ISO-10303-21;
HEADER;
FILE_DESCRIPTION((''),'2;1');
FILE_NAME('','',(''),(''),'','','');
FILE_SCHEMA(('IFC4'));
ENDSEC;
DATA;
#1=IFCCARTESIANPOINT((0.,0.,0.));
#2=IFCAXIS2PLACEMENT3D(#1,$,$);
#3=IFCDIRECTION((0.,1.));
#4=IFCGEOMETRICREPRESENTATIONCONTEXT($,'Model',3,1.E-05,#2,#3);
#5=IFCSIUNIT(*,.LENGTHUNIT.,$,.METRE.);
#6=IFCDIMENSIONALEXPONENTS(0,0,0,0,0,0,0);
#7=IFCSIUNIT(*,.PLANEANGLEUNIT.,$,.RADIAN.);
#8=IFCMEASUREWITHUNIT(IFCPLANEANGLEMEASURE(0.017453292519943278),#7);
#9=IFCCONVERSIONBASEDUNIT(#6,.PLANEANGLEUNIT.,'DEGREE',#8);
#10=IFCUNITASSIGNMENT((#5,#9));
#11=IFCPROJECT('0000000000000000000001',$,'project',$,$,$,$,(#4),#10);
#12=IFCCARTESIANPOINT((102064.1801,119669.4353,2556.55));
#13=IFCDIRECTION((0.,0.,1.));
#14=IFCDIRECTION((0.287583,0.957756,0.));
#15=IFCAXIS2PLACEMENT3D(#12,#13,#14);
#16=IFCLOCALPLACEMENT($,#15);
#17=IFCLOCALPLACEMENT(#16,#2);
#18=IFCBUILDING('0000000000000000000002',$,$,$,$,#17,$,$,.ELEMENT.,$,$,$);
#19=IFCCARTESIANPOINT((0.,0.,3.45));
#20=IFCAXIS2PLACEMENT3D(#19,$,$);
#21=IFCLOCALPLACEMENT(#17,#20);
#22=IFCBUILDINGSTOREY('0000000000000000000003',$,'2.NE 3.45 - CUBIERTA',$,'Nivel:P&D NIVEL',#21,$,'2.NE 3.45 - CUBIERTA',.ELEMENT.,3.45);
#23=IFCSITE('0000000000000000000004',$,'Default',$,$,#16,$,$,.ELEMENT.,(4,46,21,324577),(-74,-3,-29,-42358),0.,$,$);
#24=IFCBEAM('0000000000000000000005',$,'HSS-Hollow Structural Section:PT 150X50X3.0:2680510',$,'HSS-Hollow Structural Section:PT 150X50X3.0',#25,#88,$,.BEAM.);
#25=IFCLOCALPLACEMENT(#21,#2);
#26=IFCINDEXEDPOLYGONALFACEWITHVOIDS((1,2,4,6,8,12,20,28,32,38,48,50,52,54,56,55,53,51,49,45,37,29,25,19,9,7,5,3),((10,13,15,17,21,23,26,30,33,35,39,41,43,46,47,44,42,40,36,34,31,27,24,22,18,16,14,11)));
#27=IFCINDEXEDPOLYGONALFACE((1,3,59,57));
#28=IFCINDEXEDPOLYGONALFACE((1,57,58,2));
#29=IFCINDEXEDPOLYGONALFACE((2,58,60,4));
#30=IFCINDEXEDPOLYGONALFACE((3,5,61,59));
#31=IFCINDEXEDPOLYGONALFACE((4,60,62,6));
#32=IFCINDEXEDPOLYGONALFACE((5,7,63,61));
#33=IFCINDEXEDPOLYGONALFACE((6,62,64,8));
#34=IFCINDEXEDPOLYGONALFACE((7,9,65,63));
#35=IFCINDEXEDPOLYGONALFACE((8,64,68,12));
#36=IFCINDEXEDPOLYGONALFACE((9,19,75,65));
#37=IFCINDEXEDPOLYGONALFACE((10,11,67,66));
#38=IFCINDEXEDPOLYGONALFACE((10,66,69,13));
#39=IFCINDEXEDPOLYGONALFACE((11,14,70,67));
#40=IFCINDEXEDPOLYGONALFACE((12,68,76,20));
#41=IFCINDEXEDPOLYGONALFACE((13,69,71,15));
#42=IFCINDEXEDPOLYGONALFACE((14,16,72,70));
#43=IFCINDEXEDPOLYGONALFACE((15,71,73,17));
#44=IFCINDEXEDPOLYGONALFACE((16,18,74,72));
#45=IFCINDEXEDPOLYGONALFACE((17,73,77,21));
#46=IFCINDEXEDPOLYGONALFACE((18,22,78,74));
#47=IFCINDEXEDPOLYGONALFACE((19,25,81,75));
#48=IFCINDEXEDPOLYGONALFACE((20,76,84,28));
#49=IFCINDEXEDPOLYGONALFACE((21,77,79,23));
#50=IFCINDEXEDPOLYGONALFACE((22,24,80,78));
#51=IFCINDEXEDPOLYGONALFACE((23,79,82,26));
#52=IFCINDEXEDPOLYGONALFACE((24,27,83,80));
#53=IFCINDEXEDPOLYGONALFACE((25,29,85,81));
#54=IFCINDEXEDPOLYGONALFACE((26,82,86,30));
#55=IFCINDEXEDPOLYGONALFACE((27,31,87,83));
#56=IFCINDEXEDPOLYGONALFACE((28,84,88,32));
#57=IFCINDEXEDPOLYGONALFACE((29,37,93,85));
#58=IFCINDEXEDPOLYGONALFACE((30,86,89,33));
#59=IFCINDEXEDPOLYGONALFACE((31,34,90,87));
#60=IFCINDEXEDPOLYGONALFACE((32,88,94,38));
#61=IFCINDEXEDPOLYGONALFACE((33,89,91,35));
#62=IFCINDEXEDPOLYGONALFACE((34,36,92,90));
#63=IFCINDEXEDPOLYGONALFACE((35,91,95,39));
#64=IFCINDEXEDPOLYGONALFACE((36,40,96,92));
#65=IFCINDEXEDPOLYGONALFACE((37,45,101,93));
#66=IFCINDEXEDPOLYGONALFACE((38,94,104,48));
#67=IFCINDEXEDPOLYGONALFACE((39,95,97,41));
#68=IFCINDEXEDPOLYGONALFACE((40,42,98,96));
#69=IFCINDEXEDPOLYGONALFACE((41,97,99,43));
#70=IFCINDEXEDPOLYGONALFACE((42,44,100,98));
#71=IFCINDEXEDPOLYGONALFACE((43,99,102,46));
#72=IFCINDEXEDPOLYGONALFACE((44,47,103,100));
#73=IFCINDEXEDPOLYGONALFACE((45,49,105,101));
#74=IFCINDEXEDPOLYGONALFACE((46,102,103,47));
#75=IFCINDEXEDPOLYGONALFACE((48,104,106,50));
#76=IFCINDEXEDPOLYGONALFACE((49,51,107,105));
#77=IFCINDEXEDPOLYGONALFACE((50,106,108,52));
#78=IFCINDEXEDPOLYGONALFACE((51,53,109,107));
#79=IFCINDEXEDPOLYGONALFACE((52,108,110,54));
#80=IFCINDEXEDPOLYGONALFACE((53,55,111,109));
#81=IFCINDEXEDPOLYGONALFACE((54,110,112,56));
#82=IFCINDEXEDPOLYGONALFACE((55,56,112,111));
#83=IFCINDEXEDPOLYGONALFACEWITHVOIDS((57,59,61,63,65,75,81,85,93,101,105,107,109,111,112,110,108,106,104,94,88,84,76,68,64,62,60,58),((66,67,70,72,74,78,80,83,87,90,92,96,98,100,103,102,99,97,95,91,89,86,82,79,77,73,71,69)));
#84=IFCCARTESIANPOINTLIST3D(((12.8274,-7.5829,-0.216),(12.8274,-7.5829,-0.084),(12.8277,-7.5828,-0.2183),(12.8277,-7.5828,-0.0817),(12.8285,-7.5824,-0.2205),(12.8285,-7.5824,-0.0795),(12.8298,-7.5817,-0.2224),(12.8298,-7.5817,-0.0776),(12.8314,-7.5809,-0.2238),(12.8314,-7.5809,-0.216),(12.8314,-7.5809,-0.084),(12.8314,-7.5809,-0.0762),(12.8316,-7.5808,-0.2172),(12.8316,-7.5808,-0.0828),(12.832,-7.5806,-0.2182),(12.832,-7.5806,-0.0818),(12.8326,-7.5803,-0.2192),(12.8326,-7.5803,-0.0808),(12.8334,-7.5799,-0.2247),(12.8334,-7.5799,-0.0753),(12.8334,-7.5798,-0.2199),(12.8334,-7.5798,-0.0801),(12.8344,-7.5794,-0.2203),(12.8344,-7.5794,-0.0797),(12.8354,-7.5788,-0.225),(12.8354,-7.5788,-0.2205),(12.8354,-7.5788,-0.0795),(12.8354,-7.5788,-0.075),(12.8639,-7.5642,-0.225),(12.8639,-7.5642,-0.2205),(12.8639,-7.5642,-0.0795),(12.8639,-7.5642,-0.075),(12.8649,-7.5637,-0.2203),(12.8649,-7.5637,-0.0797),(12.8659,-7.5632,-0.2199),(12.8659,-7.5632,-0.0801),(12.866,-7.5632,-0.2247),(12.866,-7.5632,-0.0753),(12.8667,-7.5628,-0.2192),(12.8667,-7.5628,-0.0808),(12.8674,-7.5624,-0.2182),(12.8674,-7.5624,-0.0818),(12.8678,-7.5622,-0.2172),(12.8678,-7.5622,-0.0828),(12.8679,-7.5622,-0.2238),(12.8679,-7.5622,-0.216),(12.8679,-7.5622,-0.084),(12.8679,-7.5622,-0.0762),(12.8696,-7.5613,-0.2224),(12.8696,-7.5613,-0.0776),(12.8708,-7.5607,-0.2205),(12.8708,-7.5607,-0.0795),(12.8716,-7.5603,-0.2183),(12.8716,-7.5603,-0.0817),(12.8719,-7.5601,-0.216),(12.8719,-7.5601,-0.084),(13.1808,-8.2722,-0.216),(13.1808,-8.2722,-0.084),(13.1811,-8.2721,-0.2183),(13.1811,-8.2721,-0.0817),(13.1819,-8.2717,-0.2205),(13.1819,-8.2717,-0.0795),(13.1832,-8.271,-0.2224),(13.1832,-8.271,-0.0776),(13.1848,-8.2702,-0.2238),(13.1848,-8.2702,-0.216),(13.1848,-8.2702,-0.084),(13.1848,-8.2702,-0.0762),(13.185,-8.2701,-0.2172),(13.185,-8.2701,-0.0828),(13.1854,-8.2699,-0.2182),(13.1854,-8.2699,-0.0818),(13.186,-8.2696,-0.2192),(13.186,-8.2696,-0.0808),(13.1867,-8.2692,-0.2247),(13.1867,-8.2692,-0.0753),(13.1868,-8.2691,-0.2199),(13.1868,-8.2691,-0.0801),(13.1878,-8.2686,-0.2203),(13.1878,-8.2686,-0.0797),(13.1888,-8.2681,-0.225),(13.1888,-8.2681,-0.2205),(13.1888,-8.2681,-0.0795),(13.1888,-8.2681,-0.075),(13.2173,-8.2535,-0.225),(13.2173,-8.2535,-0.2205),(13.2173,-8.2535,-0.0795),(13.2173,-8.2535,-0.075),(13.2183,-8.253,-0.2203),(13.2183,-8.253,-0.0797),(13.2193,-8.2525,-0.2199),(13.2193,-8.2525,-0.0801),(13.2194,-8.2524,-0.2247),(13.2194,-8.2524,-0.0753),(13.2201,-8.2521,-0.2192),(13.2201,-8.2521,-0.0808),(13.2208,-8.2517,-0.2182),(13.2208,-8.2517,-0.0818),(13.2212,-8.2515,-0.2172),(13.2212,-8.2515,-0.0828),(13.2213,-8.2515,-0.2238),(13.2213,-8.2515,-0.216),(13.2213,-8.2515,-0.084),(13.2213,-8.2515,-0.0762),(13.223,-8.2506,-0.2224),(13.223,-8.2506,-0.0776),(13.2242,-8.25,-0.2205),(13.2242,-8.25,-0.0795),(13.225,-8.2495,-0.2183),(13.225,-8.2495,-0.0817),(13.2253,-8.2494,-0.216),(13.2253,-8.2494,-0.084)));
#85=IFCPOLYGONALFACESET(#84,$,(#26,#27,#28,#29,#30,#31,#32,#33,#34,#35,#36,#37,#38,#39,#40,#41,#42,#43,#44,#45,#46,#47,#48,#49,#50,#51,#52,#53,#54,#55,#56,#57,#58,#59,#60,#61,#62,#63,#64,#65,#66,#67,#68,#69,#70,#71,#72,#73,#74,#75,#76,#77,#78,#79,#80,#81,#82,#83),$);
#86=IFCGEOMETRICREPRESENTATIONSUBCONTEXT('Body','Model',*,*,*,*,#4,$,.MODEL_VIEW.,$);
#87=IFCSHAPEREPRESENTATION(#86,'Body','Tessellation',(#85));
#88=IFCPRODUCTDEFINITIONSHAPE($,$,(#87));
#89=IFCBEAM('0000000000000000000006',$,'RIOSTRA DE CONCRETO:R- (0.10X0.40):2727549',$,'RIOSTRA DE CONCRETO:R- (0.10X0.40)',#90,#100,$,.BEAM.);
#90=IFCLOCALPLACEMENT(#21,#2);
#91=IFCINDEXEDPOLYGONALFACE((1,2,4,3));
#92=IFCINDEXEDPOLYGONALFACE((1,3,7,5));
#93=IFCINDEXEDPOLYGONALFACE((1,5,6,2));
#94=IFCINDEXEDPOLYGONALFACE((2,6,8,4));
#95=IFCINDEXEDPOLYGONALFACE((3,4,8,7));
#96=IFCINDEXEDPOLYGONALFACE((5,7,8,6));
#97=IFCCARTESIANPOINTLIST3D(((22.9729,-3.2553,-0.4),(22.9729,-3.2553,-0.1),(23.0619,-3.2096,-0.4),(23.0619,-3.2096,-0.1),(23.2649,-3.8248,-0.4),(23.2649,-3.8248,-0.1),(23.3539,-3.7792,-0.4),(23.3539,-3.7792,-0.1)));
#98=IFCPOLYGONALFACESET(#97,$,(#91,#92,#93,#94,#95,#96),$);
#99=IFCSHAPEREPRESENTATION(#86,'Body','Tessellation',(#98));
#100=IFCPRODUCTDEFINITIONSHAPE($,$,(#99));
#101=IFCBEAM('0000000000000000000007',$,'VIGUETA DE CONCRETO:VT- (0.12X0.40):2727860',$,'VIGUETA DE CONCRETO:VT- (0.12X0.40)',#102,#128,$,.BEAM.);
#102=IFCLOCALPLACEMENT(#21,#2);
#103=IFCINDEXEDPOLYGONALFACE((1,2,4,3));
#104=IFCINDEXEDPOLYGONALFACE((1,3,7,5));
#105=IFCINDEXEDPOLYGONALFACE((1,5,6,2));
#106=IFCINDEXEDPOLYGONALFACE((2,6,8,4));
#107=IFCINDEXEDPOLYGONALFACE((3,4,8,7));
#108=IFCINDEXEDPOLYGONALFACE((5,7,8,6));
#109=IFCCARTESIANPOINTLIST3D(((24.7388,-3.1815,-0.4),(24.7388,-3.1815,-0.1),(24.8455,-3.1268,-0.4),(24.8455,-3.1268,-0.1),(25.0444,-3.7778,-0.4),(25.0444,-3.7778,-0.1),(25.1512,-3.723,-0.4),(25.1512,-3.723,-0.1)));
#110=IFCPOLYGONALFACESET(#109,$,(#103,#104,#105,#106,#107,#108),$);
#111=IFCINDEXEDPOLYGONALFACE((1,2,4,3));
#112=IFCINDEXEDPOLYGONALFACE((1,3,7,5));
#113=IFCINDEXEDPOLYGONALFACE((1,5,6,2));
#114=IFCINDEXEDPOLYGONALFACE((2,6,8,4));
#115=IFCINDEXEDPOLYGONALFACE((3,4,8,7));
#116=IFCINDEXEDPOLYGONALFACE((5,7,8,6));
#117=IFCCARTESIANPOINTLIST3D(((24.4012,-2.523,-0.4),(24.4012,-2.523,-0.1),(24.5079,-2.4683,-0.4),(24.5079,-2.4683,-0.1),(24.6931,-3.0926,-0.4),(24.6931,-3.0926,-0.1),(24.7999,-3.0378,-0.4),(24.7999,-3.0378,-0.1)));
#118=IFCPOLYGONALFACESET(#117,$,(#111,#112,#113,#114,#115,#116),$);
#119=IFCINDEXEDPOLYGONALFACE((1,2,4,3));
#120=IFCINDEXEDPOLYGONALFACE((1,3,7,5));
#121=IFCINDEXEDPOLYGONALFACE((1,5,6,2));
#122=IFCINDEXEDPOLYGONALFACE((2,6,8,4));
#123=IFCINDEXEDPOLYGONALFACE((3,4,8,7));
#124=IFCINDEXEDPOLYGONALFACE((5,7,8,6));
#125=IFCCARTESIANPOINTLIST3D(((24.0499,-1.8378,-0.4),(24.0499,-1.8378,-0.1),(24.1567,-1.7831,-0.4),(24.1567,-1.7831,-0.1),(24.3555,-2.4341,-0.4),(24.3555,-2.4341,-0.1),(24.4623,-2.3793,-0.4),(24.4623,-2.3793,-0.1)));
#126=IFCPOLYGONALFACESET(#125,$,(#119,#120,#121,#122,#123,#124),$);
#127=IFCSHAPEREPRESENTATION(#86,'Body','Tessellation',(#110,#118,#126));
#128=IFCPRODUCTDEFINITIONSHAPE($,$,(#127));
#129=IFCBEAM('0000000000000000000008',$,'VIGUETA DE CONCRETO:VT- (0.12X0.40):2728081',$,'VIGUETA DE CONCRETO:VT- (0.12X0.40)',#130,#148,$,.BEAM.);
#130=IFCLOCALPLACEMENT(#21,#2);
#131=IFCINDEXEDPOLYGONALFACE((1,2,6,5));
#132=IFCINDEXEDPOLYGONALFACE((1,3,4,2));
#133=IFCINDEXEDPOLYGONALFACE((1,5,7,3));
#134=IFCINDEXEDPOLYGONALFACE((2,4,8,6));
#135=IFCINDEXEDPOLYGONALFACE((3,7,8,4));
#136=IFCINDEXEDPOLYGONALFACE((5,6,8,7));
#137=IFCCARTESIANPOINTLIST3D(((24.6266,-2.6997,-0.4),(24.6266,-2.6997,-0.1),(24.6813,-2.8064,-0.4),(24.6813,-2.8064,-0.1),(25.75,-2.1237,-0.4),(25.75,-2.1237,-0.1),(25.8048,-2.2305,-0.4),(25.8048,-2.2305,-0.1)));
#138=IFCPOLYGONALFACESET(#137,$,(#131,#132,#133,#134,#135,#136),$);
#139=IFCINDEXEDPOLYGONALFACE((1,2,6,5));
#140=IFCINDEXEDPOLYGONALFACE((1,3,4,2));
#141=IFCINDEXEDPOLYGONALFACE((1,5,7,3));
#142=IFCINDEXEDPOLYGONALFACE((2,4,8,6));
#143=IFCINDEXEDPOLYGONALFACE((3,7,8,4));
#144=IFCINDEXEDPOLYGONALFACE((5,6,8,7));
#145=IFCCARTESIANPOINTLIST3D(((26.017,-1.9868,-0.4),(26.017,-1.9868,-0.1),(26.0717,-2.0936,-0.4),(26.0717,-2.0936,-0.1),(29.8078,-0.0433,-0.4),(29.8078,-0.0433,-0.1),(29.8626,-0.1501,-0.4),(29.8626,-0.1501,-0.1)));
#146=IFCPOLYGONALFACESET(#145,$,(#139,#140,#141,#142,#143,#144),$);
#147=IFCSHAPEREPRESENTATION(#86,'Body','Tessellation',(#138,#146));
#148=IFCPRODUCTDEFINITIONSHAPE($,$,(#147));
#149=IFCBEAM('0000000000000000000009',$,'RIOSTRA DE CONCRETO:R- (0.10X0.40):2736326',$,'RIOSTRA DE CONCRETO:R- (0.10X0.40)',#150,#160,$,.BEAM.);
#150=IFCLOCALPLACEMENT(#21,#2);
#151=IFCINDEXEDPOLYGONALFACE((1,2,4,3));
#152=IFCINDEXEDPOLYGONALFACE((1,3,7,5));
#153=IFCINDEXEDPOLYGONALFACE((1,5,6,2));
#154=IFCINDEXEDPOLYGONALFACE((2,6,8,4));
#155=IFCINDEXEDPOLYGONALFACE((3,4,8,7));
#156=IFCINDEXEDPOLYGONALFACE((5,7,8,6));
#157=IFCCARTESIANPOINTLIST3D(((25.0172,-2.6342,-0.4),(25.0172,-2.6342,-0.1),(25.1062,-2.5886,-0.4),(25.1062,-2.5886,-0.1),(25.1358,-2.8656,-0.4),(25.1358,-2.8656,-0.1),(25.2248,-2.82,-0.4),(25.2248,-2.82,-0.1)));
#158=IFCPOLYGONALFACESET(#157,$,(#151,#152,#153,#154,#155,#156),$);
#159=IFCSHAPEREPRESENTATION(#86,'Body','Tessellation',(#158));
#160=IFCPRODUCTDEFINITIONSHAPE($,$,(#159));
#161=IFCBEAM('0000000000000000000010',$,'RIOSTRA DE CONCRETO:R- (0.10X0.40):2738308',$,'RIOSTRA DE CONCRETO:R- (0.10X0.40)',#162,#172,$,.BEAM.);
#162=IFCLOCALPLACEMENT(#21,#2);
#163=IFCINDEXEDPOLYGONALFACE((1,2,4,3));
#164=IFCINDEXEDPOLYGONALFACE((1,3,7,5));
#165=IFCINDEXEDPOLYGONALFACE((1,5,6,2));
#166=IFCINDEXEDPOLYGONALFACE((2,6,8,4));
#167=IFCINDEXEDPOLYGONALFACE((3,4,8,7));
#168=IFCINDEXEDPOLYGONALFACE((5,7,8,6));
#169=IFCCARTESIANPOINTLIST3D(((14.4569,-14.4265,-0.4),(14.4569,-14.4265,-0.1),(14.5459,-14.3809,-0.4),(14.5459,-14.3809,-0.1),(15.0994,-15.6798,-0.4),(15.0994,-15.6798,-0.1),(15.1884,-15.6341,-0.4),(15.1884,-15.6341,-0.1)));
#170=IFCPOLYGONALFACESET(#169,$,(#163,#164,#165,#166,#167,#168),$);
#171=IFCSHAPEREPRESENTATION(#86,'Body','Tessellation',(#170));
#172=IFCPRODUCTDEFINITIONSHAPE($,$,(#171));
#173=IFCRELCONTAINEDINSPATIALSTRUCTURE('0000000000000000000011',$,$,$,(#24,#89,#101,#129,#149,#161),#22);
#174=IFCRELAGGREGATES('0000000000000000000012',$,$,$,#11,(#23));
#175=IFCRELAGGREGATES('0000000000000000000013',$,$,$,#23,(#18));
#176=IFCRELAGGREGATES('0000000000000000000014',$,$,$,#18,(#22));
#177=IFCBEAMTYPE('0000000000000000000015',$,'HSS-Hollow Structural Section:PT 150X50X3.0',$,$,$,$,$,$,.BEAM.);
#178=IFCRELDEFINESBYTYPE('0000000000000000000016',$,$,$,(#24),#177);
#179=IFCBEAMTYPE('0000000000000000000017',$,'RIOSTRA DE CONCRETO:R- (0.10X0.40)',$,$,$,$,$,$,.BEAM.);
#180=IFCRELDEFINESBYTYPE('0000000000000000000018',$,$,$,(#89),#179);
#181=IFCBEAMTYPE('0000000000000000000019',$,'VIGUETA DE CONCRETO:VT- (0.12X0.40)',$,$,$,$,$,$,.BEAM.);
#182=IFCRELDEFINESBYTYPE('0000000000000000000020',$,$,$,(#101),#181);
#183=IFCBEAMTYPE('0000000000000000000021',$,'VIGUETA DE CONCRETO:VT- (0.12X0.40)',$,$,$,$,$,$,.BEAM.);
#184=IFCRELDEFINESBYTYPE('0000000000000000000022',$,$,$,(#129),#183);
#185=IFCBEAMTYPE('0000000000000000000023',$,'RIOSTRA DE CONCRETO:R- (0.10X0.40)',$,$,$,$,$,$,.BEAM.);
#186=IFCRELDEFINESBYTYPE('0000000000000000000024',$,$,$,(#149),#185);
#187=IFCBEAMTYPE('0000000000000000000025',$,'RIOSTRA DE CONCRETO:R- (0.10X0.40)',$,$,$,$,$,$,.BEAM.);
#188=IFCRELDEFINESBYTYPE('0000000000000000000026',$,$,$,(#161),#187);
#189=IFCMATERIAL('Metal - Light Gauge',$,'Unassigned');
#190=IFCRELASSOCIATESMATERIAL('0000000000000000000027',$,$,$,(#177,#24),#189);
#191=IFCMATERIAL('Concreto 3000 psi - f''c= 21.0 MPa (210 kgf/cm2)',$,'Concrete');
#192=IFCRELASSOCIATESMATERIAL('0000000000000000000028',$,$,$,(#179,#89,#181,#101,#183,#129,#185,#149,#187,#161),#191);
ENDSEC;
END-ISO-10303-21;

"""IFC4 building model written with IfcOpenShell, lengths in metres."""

from ifc_helpers import new_model, entity, si_unit, converted_unit, direction, frame, origin, place, context, subcontext, project, spatial, line, arc, indexed_curve, outline, extrude, source, transform, mapped, material, type_object, type_shapes, element, save


model = new_model("IFC4")

# Units and contexts
model_context = context("Model", 3, precision=1e-05, world=origin(), true_north=direction((0.0, 1.0)))
body_context = subcontext(model_context, "Body", "Model", "MODEL_VIEW")
ifc_project = project(units=[si_unit("LENGTHUNIT", "METRE"), converted_unit("PLANEANGLEUNIT", "DEGREE", entity("IfcPlaneAngleMeasure", 0.017453292519943278), si_unit("PLANEANGLEUNIT", "RADIAN"), dimensions=[0, 0, 0, 0, 0, 0, 0])], contexts=[model_context])

# Site, building, storey
site_placement = place(None, frame((102064.1801, 119669.4353, 2556.55), z_axis=(0.0, 0.0, 1.0), x_axis=(0.287583, 0.957756, 0.0)))
site = spatial("IfcSite", under=ifc_project, at=site_placement, Name="Default", CompositionType="ELEMENT", RefLatitude=(4, 46, 21, 324577), RefLongitude=(-74, -3, -29, -42358), RefElevation=0.0)
building_placement = place(site_placement, origin())
building = spatial("IfcBuilding", under=site, at=building_placement, CompositionType="ELEMENT")
storey_placement = place(building_placement, frame((0.0, 0.0, 3.45)))
storey = spatial("IfcBuildingStorey", under=building, at=storey_placement, Name="2.NE 3.45 - CUBIERTA", ObjectType="Nivel:P&D NIVEL", LongName="2.NE 3.45 - CUBIERTA", CompositionType="ELEMENT", Elevation=3.45)

# Beams
ifc_material_1 = material(Name="Metal - Light Gauge", Category="Unassigned")
beam_type_1 = type_object("IfcBeamType", Name="HSS-Hollow Structural Section:PT 150X50X3.0", PredefinedType="BEAM", material=ifc_material_1)
shared_shape_1 = source(origin(), body_context, "Body", "SweptSolid", [
    extrude(outline(indexed_curve([(-0.025, -0.066), (-0.0224, -0.0724), (-0.016, -0.075), (0.016, -0.075), (0.0224, -0.0724), (0.025, -0.066), (0.025, 0.066), (0.0224, 0.0724), (0.016, 0.075), (-0.016, 0.075), (-0.0224, 0.0724), (-0.025, 0.066)], segments=[arc(1, 2, 3), line(3, 4), arc(4, 5, 6), line(6, 7), arc(7, 8, 9), line(9, 10), arc(10, 11, 12), line(12, 1)], self_intersect=False), holes=[indexed_curve([(0.016, -0.0705), (-0.016, -0.0705), (-0.0192, -0.0692), (-0.0205, -0.066), (-0.0205, 0.066), (-0.0192, 0.0692), (-0.016, 0.0705), (0.016, 0.0705), (0.0192, 0.0692), (0.0205, 0.066), (0.0205, -0.066), (0.0192, -0.0692)], segments=[line(1, 2), arc(2, 3, 4), line(4, 5), arc(5, 6, 7), line(7, 8), arc(8, 9, 10), line(10, 11), arc(11, 12, 1)], self_intersect=False)]), frame((-0.3873, 0.0, 0.0), z_axis=(1.0, 0.0, 0.0), x_axis=(0.0, -1.0, 0.0)), (0.0, 0.0, 1.0), 0.7746),
])
type_shapes(beam_type_1, [shared_shape_1])
for number, where, z_axis, x_axis, name in (
    (1, (13.0264, -7.9162, -0.15), (0.0, 0.0, 1.0), (-0.456217, 0.889869, 0.0), "HSS-Hollow Structural Section:PT 150X50X3.0:2680510"),
):
    element("IfcBeam", number, at=place(storey_placement, frame(where, z_axis=z_axis, x_axis=x_axis)), inside=storey, type_object=beam_type_1, material=ifc_material_1, Name=name, ObjectType="HSS-Hollow Structural Section:PT 150X50X3.0", PredefinedType="BEAM", context=body_context, shape_type="MappedRepresentation", body=[
        mapped(shared_shape_1, transform((0.0, 0.0, 0.0), scale=1.0)),
    ])
ifc_material_2 = material(Name="Concreto 3000 psi - f'c= 21.0 MPa (210 kgf/cm2)", Category="Concrete")
beam_type_2 = type_object("IfcBeamType", Name="RIOSTRA DE CONCRETO:R- (0.10X0.40)", PredefinedType="BEAM", material=ifc_material_2)
shared_shape_2 = source(origin(), body_context, "Body", "SweptSolid", [
    extrude(outline(indexed_curve([(-0.15, -0.05), (0.15, -0.05), (0.15, 0.05), (-0.15, 0.05), (-0.15, -0.05)], self_intersect=False)), frame((23.0174, -3.2325, 3.2), z_axis=(0.456217, -0.889869, 0.0), x_axis=(0.0, 0.0, -1.0)), (0.0, 0.0, 1.0), 0.64),
])
type_shapes(beam_type_2, [shared_shape_2])
beam_1_placement = place(storey_placement, frame((0.0, 0.0, -3.45)))
element("IfcBeam", 2, at=beam_1_placement, inside=storey, type_object=beam_type_2, material=ifc_material_2, Name="RIOSTRA DE CONCRETO:R- (0.10X0.40):2727549", ObjectType="RIOSTRA DE CONCRETO:R- (0.10X0.40)", PredefinedType="BEAM", context=body_context, shape_type="MappedRepresentation", body=[
    mapped(shared_shape_2, transform((0.0, 0.0, 0.0), scale=1.0)),
])
beam_type_3 = type_object("IfcBeamType", Name="VIGUETA DE CONCRETO:VT- (0.12X0.40)", PredefinedType="BEAM", material=ifc_material_2)
shared_shape_3 = source(origin(), body_context, "Body", "SweptSolid", [
    extrude(outline(indexed_curve([(-0.15, -0.06), (0.15, -0.06), (0.15, 0.06), (-0.15, 0.06), (-0.15, -0.06)], self_intersect=False)), frame((24.7921, -3.1542, 3.2), z_axis=(0.456217, -0.889869, 0.0), x_axis=(0.0, 0.0, -1.0)), (0.0, 0.0, 1.0), 0.67),
    extrude(outline(indexed_curve([(-0.15, -0.06), (0.15, -0.06), (0.15, 0.06), (-0.15, 0.06), (-0.15, -0.06)], self_intersect=False)), frame((24.4545, -2.4957, 3.2), z_axis=(0.456217, -0.889869, 0.0), x_axis=(0.0, 0.0, -1.0)), (0.0, 0.0, 1.0), 0.64),
    extrude(outline(indexed_curve([(-0.15, -0.06), (0.15, -0.06), (0.15, 0.06), (-0.15, 0.06), (-0.15, -0.06)], self_intersect=False)), frame((24.1033, -1.8105, 3.2), z_axis=(0.456217, -0.889869, 0.0), x_axis=(0.0, 0.0, -1.0)), (0.0, 0.0, 1.0), 0.67),
])
type_shapes(beam_type_3, [shared_shape_3])
beam_2_placement = place(storey_placement, frame((0.0, 0.0, -3.45)))
element("IfcBeam", 3, at=beam_2_placement, inside=storey, type_object=beam_type_3, material=ifc_material_2, Name="VIGUETA DE CONCRETO:VT- (0.12X0.40):2727860", ObjectType="VIGUETA DE CONCRETO:VT- (0.12X0.40)", PredefinedType="BEAM", context=body_context, shape_type="MappedRepresentation", body=[
    mapped(shared_shape_3, transform((0.0, 0.0, 0.0), scale=1.0)),
])
beam_type_4 = type_object("IfcBeamType", Name="VIGUETA DE CONCRETO:VT- (0.12X0.40)", PredefinedType="BEAM", material=ifc_material_2)
shared_shape_4 = source(origin(), body_context, "Body", "SweptSolid", [
    extrude(outline(indexed_curve([(-0.15, -0.06), (0.15, -0.06), (0.15, 0.06), (-0.15, 0.06), (-0.15, -0.06)], self_intersect=False)), frame((25.7774, -2.1771, 3.2), z_axis=(-0.889869, -0.456217, 0.0), x_axis=(0.0, 0.0, -1.0)), (0.0, 0.0, 1.0), 1.2625),
    extrude(outline(indexed_curve([(-0.15, -0.06), (0.15, -0.06), (0.15, 0.06), (-0.15, 0.06), (-0.15, -0.06)], self_intersect=False)), frame((29.8352, -0.0967, 3.2), z_axis=(-0.889869, -0.456217, 0.0), x_axis=(0.0, 0.0, -1.0)), (0.0, 0.0, 1.0), 4.26),
])
type_shapes(beam_type_4, [shared_shape_4])
beam_3_placement = place(storey_placement, frame((0.0, 0.0, -3.45)))
element("IfcBeam", 4, at=beam_3_placement, inside=storey, type_object=beam_type_4, material=ifc_material_2, Name="VIGUETA DE CONCRETO:VT- (0.12X0.40):2728081", ObjectType="VIGUETA DE CONCRETO:VT- (0.12X0.40)", PredefinedType="BEAM", context=body_context, shape_type="MappedRepresentation", body=[
    mapped(shared_shape_4, transform((0.0, 0.0, 0.0), scale=1.0)),
])
beam_type_5 = type_object("IfcBeamType", Name="RIOSTRA DE CONCRETO:R- (0.10X0.40)", PredefinedType="BEAM", material=ifc_material_2)
shared_shape_5 = source(origin(), body_context, "Body", "SweptSolid", [
    extrude(outline(indexed_curve([(-0.15, -0.05), (0.15, -0.05), (0.15, 0.05), (-0.15, 0.05), (-0.15, -0.05)], self_intersect=False)), frame((25.0617, -2.6114, 3.2), z_axis=(0.456217, -0.889869, 0.0), x_axis=(0.0, 0.0, -1.0)), (0.0, 0.0, 1.0), 0.26),
])
type_shapes(beam_type_5, [shared_shape_5])
beam_4_placement = place(storey_placement, frame((0.0, 0.0, -3.45)))
element("IfcBeam", 5, at=beam_4_placement, inside=storey, type_object=beam_type_5, material=ifc_material_2, Name="RIOSTRA DE CONCRETO:R- (0.10X0.40):2736326", ObjectType="RIOSTRA DE CONCRETO:R- (0.10X0.40)", PredefinedType="BEAM", context=body_context, shape_type="MappedRepresentation", body=[
    mapped(shared_shape_5, transform((0.0, 0.0, 0.0), scale=1.0)),
])
beam_type_6 = type_object("IfcBeamType", Name="RIOSTRA DE CONCRETO:R- (0.10X0.40)", PredefinedType="BEAM", material=ifc_material_2)
shared_shape_6 = source(origin(), body_context, "Body", "SweptSolid", [
    extrude(outline(indexed_curve([(-0.15, -0.05), (0.15, -0.05), (0.15, 0.05), (-0.15, 0.05), (-0.15, -0.05)], self_intersect=False)), frame((14.5014, -14.4037, 3.2), z_axis=(0.456217, -0.889869, 0.0), x_axis=(0.0, 0.0, -1.0)), (0.0, 0.0, 1.0), 1.4083),
])
type_shapes(beam_type_6, [shared_shape_6])
beam_5_placement = place(storey_placement, frame((0.0, 0.0, -3.45)))
element("IfcBeam", 6, at=beam_5_placement, inside=storey, type_object=beam_type_6, material=ifc_material_2, Name="RIOSTRA DE CONCRETO:R- (0.10X0.40):2738308", ObjectType="RIOSTRA DE CONCRETO:R- (0.10X0.40)", PredefinedType="BEAM", context=body_context, shape_type="MappedRepresentation", body=[
    mapped(shared_shape_6, transform((0.0, 0.0, 0.0), scale=1.0)),
])

save(model, "model.ifc")
